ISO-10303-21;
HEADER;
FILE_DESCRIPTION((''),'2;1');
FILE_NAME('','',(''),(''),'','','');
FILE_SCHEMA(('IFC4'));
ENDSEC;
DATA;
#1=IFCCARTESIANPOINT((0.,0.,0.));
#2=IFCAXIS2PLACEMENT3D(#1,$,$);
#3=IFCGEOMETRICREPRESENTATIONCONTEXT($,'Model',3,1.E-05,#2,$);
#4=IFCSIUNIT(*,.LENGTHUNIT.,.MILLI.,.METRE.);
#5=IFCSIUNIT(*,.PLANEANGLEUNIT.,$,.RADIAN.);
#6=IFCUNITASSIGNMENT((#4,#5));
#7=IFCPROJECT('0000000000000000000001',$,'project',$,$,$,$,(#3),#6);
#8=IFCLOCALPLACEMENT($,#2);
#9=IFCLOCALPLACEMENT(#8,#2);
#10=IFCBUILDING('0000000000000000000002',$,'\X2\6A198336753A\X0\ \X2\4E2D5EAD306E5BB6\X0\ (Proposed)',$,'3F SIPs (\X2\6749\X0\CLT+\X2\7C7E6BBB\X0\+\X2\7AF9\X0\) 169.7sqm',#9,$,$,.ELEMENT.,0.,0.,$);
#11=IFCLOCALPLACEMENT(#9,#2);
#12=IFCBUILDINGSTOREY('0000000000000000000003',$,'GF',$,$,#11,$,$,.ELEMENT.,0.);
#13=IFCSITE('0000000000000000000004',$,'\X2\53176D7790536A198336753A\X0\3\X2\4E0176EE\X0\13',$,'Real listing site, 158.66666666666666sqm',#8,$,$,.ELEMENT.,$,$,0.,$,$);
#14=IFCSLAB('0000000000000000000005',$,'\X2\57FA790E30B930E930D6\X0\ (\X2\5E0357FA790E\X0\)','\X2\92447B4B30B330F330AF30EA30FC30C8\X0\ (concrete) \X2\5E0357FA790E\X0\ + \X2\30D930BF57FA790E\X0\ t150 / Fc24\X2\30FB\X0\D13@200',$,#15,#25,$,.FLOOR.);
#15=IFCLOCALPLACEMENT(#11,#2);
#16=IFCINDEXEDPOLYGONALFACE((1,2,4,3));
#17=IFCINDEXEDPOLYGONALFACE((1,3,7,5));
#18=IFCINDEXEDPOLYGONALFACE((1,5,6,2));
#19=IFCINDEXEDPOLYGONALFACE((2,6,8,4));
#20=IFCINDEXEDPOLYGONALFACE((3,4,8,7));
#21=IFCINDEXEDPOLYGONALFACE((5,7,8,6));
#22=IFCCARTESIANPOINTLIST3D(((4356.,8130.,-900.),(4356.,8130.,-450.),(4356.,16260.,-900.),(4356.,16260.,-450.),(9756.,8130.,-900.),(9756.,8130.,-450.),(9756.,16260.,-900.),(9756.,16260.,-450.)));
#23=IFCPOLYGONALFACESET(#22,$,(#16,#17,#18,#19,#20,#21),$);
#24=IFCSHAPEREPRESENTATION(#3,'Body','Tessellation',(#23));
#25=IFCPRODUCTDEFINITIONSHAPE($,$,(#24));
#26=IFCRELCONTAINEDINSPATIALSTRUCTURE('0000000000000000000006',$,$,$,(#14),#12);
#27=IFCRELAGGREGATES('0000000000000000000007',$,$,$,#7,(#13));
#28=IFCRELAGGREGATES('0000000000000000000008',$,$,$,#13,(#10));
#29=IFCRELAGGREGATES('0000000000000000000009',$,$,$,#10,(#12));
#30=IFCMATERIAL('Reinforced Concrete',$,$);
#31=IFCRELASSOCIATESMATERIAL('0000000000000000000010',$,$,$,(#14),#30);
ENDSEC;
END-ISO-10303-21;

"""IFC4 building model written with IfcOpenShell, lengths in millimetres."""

from ifc_helpers import new_model, si_unit, frame, frame_2d, origin, place, context, project, spatial, rectangle, extrude, material, element, save


model = new_model("IFC4")

# Units and contexts
model_context = context("Model", 3, precision=1e-05, world=origin())
ifc_project = project(units=[si_unit("LENGTHUNIT", "METRE", prefix="MILLI"), si_unit("PLANEANGLEUNIT", "RADIAN")], contexts=[model_context])

# Site, building, storey
site_placement = place(None, origin())
site = spatial("IfcSite", under=ifc_project, at=site_placement, Name="北海道標茶町3丁目13", ObjectType="Real listing site, 158.66666666666666sqm", CompositionType="ELEMENT", RefElevation=0.0)
building_placement = place(site_placement, origin())
building = spatial("IfcBuilding", under=site, at=building_placement, Name="標茶町 中庭の家 (Proposed)", ObjectType="3F SIPs (杉CLT+籾殻+竹) 169.7sqm", CompositionType="ELEMENT", ElevationOfRefHeight=0.0, ElevationOfTerrain=0.0)
storey_placement = place(building_placement, origin())
storey = spatial("IfcBuildingStorey", under=building, at=storey_placement, Name="GF", CompositionType="ELEMENT", Elevation=0.0)

# Slab
ifc_material_1 = material(Name="Reinforced Concrete")
slab_1_placement = place(storey_placement, frame((2178.0, 4065.0, -450.0)))
element("IfcSlab", 1, at=slab_1_placement, inside=storey, material=ifc_material_1, Name="基礎スラブ (布基礎)", Description="鉄筋コンクリート (concrete) 布基礎 + ベタ基礎 t150 / Fc24・D13@200", PredefinedType="FLOOR", context=model_context, shape_type="SweptSolid", body=[
    extrude(rectangle(XDim=5400.0, YDim=8130.0, at=frame_2d((2700.0, 4065.0))), frame((2178.0, 4065.0, -450.0)), (0.0, 0.0, 1.0), 450.0),
])

save(model, "model.ifc")
